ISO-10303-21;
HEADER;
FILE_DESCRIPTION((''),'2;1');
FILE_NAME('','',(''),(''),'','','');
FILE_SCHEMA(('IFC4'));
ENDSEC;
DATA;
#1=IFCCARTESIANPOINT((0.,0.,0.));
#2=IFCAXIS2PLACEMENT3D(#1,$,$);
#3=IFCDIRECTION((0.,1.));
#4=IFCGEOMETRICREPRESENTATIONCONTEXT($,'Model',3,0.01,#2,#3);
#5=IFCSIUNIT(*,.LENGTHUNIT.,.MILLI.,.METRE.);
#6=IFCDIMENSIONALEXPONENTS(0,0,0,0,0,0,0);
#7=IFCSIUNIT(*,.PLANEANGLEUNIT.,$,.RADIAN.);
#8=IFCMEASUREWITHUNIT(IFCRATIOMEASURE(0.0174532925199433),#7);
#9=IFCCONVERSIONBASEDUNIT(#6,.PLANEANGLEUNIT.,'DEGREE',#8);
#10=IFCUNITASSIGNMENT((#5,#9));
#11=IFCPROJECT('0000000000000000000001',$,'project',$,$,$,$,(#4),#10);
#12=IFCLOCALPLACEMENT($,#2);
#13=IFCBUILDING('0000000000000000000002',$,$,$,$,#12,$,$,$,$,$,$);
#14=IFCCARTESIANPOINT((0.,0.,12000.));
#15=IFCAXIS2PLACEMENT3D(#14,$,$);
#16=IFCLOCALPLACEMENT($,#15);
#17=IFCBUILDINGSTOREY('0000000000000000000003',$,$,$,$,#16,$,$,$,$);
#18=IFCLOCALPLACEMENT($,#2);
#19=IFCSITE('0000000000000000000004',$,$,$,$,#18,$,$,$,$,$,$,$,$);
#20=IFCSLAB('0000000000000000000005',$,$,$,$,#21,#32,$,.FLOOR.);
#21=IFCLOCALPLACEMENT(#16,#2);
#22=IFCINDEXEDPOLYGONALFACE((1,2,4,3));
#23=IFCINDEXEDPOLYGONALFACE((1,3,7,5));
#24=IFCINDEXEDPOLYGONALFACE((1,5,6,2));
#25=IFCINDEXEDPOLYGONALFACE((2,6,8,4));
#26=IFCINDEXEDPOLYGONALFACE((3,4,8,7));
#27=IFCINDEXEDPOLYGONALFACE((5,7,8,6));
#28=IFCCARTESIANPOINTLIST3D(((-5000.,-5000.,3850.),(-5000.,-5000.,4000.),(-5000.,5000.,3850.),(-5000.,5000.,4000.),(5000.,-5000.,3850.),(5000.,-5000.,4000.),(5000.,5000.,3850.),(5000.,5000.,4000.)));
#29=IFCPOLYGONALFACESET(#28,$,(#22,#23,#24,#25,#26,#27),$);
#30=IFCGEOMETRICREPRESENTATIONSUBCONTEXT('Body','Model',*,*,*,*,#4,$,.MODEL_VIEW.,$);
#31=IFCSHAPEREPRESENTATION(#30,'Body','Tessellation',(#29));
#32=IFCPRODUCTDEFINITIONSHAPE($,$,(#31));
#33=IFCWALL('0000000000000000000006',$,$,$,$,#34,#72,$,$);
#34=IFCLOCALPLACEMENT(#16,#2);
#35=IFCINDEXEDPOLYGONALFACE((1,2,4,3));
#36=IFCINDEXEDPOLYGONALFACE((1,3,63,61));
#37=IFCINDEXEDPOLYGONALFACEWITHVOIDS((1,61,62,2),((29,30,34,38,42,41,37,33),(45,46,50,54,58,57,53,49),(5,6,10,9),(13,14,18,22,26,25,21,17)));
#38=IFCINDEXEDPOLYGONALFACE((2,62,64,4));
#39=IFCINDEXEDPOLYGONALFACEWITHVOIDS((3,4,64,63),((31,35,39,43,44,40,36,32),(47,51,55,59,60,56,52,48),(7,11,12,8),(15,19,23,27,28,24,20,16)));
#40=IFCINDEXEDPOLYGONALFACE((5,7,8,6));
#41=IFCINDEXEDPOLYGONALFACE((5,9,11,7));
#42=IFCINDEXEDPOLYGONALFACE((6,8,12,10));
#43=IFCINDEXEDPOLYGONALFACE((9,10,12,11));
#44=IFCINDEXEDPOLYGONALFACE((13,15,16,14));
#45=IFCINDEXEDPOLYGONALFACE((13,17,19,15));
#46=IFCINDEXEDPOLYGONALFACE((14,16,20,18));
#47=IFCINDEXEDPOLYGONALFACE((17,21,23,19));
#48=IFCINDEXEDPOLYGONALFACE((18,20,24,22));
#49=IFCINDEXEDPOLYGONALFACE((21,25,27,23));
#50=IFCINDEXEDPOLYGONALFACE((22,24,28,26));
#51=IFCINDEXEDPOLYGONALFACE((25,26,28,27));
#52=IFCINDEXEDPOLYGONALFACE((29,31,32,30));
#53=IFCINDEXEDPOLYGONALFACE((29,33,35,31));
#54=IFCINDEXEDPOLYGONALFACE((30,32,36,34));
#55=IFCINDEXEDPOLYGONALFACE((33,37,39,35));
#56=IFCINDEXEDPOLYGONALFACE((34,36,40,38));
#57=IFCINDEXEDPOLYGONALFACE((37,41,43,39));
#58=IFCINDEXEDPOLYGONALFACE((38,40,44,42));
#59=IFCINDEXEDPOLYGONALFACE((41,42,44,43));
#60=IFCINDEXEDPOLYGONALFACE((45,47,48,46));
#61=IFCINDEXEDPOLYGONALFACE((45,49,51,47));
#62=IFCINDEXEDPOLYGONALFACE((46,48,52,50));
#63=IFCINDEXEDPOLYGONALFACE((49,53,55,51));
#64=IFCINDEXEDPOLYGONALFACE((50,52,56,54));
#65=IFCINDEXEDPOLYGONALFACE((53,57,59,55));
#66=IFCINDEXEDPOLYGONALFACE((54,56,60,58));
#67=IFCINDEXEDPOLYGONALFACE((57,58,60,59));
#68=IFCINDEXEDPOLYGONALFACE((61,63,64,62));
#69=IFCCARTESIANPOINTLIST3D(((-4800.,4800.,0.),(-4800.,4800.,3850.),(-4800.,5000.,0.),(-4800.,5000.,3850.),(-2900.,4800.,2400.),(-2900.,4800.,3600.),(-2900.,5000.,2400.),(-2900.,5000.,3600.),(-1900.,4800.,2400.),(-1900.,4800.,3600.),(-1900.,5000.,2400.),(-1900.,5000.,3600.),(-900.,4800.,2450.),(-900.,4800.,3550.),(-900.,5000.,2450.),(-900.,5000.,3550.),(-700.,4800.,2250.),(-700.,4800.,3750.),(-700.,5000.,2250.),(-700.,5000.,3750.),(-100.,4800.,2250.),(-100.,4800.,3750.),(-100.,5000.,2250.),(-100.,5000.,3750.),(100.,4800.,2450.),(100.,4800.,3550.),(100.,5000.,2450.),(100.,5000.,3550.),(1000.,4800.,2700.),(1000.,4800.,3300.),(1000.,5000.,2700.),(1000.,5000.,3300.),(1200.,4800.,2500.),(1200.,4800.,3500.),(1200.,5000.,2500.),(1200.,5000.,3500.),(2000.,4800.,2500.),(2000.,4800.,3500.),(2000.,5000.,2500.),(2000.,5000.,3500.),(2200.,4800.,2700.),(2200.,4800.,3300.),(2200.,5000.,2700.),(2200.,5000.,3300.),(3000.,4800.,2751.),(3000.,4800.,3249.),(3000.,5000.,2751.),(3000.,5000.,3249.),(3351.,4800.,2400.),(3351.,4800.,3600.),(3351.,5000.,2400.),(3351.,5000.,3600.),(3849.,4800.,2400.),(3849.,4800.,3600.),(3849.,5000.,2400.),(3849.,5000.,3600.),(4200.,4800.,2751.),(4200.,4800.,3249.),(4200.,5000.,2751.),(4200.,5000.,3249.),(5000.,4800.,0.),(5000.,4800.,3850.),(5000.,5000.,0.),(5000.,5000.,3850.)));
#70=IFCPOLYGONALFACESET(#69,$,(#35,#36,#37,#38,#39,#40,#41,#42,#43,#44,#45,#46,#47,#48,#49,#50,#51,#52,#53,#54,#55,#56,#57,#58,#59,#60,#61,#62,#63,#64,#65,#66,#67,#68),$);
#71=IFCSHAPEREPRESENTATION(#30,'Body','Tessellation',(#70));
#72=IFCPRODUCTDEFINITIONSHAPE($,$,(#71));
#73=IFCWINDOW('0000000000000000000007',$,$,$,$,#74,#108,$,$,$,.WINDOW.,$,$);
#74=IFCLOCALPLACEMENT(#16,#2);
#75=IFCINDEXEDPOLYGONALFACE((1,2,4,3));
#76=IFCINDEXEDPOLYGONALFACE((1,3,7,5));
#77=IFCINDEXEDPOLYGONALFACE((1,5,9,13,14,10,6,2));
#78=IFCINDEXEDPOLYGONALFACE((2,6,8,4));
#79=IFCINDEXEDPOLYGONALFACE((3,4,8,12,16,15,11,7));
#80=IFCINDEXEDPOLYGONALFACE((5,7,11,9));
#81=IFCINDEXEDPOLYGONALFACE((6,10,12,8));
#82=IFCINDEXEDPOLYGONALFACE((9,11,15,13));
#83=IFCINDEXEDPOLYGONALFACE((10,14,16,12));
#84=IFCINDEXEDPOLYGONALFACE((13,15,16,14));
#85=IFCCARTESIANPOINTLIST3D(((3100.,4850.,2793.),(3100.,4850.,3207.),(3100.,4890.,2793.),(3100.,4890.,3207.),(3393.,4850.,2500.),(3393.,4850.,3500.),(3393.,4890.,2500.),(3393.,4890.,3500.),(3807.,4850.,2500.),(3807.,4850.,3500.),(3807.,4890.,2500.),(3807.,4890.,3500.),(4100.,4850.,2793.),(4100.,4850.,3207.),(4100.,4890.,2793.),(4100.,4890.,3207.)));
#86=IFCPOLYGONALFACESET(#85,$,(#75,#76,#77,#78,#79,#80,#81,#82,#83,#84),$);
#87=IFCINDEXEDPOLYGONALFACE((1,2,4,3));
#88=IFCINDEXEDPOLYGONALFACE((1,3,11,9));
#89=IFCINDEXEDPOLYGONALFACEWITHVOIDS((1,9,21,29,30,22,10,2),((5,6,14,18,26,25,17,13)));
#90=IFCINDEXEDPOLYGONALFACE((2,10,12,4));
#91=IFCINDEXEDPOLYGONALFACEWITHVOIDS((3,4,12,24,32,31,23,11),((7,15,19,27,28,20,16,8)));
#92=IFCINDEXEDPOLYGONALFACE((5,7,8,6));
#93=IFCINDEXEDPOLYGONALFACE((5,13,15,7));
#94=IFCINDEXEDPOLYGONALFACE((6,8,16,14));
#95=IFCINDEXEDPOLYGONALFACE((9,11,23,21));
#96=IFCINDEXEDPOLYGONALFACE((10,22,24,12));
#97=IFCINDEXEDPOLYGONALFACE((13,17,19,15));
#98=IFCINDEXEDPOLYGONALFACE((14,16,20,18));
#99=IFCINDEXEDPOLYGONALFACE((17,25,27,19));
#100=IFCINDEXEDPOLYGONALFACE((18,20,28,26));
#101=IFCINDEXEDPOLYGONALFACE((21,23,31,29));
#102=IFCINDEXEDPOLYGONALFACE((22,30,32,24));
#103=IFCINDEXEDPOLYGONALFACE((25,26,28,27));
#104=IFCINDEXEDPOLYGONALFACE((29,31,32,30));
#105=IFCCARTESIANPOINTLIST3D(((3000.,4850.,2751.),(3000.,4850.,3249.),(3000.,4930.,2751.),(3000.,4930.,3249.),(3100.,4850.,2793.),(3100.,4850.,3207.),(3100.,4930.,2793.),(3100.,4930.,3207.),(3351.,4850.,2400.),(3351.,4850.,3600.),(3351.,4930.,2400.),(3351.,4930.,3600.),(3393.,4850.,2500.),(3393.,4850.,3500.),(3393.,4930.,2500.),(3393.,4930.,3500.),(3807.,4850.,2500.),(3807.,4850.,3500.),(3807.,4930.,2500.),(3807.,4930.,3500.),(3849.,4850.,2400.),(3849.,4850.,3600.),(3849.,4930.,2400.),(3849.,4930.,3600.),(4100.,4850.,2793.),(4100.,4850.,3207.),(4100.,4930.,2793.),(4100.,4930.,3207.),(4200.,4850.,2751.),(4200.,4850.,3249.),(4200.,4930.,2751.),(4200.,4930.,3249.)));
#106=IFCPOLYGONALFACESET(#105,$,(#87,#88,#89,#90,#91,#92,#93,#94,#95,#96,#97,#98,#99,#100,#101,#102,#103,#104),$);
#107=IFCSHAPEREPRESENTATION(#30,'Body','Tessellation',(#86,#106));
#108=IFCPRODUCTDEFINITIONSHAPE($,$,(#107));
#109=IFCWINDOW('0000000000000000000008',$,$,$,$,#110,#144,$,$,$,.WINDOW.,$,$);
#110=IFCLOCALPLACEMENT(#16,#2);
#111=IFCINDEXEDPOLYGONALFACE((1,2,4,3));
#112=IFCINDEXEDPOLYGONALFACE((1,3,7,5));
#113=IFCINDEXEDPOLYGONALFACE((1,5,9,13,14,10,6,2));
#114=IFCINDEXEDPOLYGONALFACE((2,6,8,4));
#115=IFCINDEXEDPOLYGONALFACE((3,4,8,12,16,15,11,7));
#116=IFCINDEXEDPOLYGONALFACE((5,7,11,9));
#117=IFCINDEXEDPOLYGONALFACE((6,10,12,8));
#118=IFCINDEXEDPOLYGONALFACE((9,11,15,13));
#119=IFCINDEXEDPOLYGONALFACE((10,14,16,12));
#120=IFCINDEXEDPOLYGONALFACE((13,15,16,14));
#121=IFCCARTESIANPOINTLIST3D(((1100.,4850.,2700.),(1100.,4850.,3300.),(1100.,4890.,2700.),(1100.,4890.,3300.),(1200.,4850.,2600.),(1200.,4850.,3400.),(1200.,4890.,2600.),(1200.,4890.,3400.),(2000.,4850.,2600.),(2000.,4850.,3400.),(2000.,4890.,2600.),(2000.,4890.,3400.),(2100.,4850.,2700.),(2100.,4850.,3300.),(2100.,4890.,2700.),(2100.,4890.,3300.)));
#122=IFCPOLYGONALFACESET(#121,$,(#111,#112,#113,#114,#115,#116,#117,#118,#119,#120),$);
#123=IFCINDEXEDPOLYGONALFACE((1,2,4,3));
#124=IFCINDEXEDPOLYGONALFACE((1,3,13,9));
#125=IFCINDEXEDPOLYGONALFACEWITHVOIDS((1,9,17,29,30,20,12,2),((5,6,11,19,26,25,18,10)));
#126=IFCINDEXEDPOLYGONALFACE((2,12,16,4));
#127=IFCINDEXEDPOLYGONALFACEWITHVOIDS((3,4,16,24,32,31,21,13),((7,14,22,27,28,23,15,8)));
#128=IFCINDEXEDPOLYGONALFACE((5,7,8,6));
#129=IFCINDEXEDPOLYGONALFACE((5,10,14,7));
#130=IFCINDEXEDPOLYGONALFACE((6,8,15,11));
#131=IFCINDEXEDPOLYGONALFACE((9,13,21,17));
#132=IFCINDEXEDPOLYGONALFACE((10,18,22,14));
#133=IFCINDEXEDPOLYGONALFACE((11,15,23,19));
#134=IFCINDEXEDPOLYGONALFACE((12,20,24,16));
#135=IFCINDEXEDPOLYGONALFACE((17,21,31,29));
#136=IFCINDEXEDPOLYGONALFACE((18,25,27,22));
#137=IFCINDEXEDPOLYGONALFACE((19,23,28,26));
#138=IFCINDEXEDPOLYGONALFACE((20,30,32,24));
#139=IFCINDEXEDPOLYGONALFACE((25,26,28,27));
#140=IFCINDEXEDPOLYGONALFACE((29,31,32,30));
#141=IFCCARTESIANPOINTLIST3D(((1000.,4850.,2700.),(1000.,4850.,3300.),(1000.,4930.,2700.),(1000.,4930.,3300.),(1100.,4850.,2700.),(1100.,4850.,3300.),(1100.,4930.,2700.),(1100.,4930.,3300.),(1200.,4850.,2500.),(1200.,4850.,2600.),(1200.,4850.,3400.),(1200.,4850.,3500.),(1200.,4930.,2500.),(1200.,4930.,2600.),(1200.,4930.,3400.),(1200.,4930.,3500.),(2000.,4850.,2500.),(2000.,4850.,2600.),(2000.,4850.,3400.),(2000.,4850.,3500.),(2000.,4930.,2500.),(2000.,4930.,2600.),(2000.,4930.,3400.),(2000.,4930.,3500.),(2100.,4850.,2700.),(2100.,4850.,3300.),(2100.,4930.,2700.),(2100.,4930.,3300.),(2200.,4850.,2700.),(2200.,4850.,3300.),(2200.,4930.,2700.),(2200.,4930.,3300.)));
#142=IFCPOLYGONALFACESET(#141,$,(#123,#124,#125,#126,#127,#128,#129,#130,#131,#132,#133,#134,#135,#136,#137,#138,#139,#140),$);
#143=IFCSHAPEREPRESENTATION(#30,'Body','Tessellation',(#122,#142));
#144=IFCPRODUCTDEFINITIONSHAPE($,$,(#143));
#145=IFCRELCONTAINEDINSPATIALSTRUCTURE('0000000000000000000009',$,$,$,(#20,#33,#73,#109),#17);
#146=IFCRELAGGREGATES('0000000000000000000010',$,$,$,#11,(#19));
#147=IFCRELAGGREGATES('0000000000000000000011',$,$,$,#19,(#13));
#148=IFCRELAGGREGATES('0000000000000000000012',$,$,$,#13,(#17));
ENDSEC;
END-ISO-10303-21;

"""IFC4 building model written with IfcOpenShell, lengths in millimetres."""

from ifc_helpers import new_model, entity, si_unit, converted_unit, direction, frame, origin, origin_2d, place, context, subcontext, project, spatial, polyline, rectangle, outline, extrude, element, save


model = new_model("IFC4")

# Units and contexts
model_context = context("Model", 3, precision=0.01, world=origin(), true_north=direction((0.0, 1.0)))
body_context = subcontext(model_context, "Body", "Model", "MODEL_VIEW")
ifc_project = project(units=[si_unit("LENGTHUNIT", "METRE", prefix="MILLI"), converted_unit("PLANEANGLEUNIT", "DEGREE", entity("IfcRatioMeasure", 0.0174532925199433), si_unit("PLANEANGLEUNIT", "RADIAN"), dimensions=[0, 0, 0, 0, 0, 0, 0])], contexts=[model_context])

# Site, building, storey
site_placement = place(None, origin())
site = spatial("IfcSite", under=ifc_project, at=site_placement)
building_placement = place(None, origin())
building = spatial("IfcBuilding", under=site, at=building_placement)
storey_placement = place(None, frame((0.0, 0.0, 12000.0)))
storey = spatial("IfcBuildingStorey", under=building, at=storey_placement)

# Slab
slab_placement = place(storey_placement, frame((0.0, 0.0, 3850.0)))
element("IfcSlab", 1, at=slab_placement, inside=storey, PredefinedType="FLOOR", context=body_context, shape_type="SweptSolid", body=[
    extrude(rectangle(XDim=10000.0, YDim=10000.0, at=origin_2d()), origin(), (0.0, 0.0, 1.0), 150.0),
])

# Wall, openings
wall_1_placement = place(storey_placement, frame((100.0, 4900.0, 0.0), z_axis=(0.0, 0.0, 1.0), x_axis=(-1.0, 0.0, 0.0)))
wall_1 = element("IfcWall", 2, at=wall_1_placement, inside=storey, context=body_context, shape_type="SweptSolid", body=[
    extrude(rectangle(XDim=9800.0, YDim=200.0, at=origin_2d()), origin(), (0.0, 0.0, 1.0), 3850.0),
])
window_1_placement = place(wall_1_placement, frame((-3500.0, 50.0, 3000.0)))
opening_1_placement = place(window_1_placement, frame((0.0, 50.0, 0.0)))
element("IfcOpeningElement", 3, at=opening_1_placement, cuts=wall_1, context=body_context, shape_type="SweptSolid", body=[
    extrude(outline(polyline([(-600.0, -249.0), (-600.0, 249.0), (-249.0, 600.0), (249.0, 600.0), (600.0, 249.0), (600.0, -249.0), (249.0, -600.0), (-249.0, -600.0), (-600.0, -249.0)])), frame((0.0, 0.0, 0.0), z_axis=(0.0, -1.0, 0.0), x_axis=(1.0, 0.0, 0.0)), (0.0, 0.0, 1.0), 200.0),
])
window_2_placement = place(wall_1_placement, frame((-1500.0, 50.0, 3000.0)))
opening_2_placement = place(window_2_placement, frame((0.0, 50.0, 0.0)))
element("IfcOpeningElement", 4, at=opening_2_placement, cuts=wall_1, context=body_context, shape_type="SweptSolid", body=[
    extrude(outline(polyline([(-600.0, -300.0), (-600.0, 300.0), (-400.0, 500.0), (400.0, 500.0), (600.0, 300.0), (600.0, -300.0), (400.0, -500.0), (-400.0, -500.0), (-600.0, -300.0)])), frame((0.0, 0.0, 0.0), z_axis=(0.0, -1.0, 0.0), x_axis=(1.0, 0.0, 0.0)), (0.0, 0.0, 1.0), 200.0),
])
window_3_placement = place(wall_1_placement, frame((500.0, 50.0, 3000.0)))
opening_3_placement = place(window_3_placement, frame((0.0, 50.0, 0.0)))
element("IfcOpeningElement", 5, at=opening_3_placement, cuts=wall_1, context=body_context, shape_type="SweptSolid", body=[
    extrude(outline(polyline([(-500.0, -550.0), (-500.0, 550.0), (-300.0, 750.0), (300.0, 750.0), (500.0, 550.0), (500.0, -550.0), (300.0, -750.0), (-300.0, -750.0), (-500.0, -550.0)])), frame((0.0, 0.0, 0.0), z_axis=(0.0, -1.0, 0.0), x_axis=(1.0, 0.0, 0.0)), (0.0, 0.0, 1.0), 200.0),
])
window_4_placement = place(wall_1_placement, frame((2500.0, 50.0, 3000.0)))
opening_4_placement = place(window_4_placement, frame((0.0, 50.0, 0.0)))
element("IfcOpeningElement", 6, at=opening_4_placement, cuts=wall_1, context=body_context, shape_type="SweptSolid", body=[
    extrude(outline(polyline([(-500.0, -600.0), (-500.0, 600.0), (-500.0, 600.0), (500.0, 600.0), (500.0, 600.0), (500.0, -600.0), (500.0, -600.0), (-500.0, -600.0), (-500.0, -600.0)])), frame((0.0, 0.0, 0.0), z_axis=(0.0, -1.0, 0.0), x_axis=(1.0, 0.0, 0.0)), (0.0, 0.0, 1.0), 200.0),
])

# Windows
cartesian_point_1 = entity("IfcCartesianPoint", [-500.0, -207.0])
shared_polyline_1 = entity("IfcPolyline", [cartesian_point_1, entity("IfcCartesianPoint", [-500.0, 207.0]), entity("IfcCartesianPoint", [-207.0, 500.0]), entity("IfcCartesianPoint", [207.0, 500.0]), entity("IfcCartesianPoint", [500.0, 207.0]), entity("IfcCartesianPoint", [500.0, -207.0]), entity("IfcCartesianPoint", [207.0, -500.0]), entity("IfcCartesianPoint", [-207.0, -500.0]), cartesian_point_1])
cartesian_point_2 = entity("IfcCartesianPoint", [-600.0, -249.0])
element("IfcWindow", 7, at=window_1_placement, inside=storey, PredefinedType="WINDOW", context=body_context, shape_type="SweptSolid", body=[
    entity("IfcExtrudedAreaSolid", entity("IfcArbitraryClosedProfileDef", "AREA", None, shared_polyline_1), entity("IfcAxis2Placement3D", entity("IfcCartesianPoint", [0.0, 0.0, 0.0]), entity("IfcDirection", [0.0, -1.0, 0.0]), entity("IfcDirection", [1.0, 0.0, 0.0])), entity("IfcDirection", [0.0, 0.0, 1.0]), 40.0),
    entity("IfcExtrudedAreaSolid", entity("IfcArbitraryProfileDefWithVoids", "AREA", None, entity("IfcPolyline", [cartesian_point_2, entity("IfcCartesianPoint", [-600.0, 249.0]), entity("IfcCartesianPoint", [-249.0, 600.0]), entity("IfcCartesianPoint", [249.0, 600.0]), entity("IfcCartesianPoint", [600.0, 249.0]), entity("IfcCartesianPoint", [600.0, -249.0]), entity("IfcCartesianPoint", [249.0, -600.0]), entity("IfcCartesianPoint", [-249.0, -600.0]), cartesian_point_2]), [shared_polyline_1]), entity("IfcAxis2Placement3D", entity("IfcCartesianPoint", [0.0, 0.0, 0.0]), entity("IfcDirection", [0.0, -1.0, 0.0]), entity("IfcDirection", [1.0, 0.0, 0.0])), entity("IfcDirection", [0.0, 0.0, 1.0]), 80.0),
])
cartesian_point_3 = entity("IfcCartesianPoint", [-500.0, -300.0])
shared_polyline_2 = entity("IfcPolyline", [cartesian_point_3, entity("IfcCartesianPoint", [-500.0, 300.0]), entity("IfcCartesianPoint", [-400.0, 400.0]), entity("IfcCartesianPoint", [400.0, 400.0]), entity("IfcCartesianPoint", [500.0, 300.0]), entity("IfcCartesianPoint", [500.0, -300.0]), entity("IfcCartesianPoint", [400.0, -400.0]), entity("IfcCartesianPoint", [-400.0, -400.0]), cartesian_point_3])
cartesian_point_4 = entity("IfcCartesianPoint", [-600.0, -300.0])
element("IfcWindow", 8, at=window_2_placement, inside=storey, PredefinedType="WINDOW", context=body_context, shape_type="SweptSolid", body=[
    entity("IfcExtrudedAreaSolid", entity("IfcArbitraryClosedProfileDef", "AREA", None, shared_polyline_2), entity("IfcAxis2Placement3D", entity("IfcCartesianPoint", [0.0, 0.0, 0.0]), entity("IfcDirection", [0.0, -1.0, 0.0]), entity("IfcDirection", [1.0, 0.0, 0.0])), entity("IfcDirection", [0.0, 0.0, 1.0]), 40.0),
    entity("IfcExtrudedAreaSolid", entity("IfcArbitraryProfileDefWithVoids", "AREA", None, entity("IfcPolyline", [cartesian_point_4, entity("IfcCartesianPoint", [-600.0, 300.0]), entity("IfcCartesianPoint", [-400.0, 500.0]), entity("IfcCartesianPoint", [400.0, 500.0]), entity("IfcCartesianPoint", [600.0, 300.0]), entity("IfcCartesianPoint", [600.0, -300.0]), entity("IfcCartesianPoint", [400.0, -500.0]), entity("IfcCartesianPoint", [-400.0, -500.0]), cartesian_point_4]), [shared_polyline_2]), entity("IfcAxis2Placement3D", entity("IfcCartesianPoint", [0.0, 0.0, 0.0]), entity("IfcDirection", [0.0, -1.0, 0.0]), entity("IfcDirection", [1.0, 0.0, 0.0])), entity("IfcDirection", [0.0, 0.0, 1.0]), 80.0),
])

save(model, "model.ifc")
